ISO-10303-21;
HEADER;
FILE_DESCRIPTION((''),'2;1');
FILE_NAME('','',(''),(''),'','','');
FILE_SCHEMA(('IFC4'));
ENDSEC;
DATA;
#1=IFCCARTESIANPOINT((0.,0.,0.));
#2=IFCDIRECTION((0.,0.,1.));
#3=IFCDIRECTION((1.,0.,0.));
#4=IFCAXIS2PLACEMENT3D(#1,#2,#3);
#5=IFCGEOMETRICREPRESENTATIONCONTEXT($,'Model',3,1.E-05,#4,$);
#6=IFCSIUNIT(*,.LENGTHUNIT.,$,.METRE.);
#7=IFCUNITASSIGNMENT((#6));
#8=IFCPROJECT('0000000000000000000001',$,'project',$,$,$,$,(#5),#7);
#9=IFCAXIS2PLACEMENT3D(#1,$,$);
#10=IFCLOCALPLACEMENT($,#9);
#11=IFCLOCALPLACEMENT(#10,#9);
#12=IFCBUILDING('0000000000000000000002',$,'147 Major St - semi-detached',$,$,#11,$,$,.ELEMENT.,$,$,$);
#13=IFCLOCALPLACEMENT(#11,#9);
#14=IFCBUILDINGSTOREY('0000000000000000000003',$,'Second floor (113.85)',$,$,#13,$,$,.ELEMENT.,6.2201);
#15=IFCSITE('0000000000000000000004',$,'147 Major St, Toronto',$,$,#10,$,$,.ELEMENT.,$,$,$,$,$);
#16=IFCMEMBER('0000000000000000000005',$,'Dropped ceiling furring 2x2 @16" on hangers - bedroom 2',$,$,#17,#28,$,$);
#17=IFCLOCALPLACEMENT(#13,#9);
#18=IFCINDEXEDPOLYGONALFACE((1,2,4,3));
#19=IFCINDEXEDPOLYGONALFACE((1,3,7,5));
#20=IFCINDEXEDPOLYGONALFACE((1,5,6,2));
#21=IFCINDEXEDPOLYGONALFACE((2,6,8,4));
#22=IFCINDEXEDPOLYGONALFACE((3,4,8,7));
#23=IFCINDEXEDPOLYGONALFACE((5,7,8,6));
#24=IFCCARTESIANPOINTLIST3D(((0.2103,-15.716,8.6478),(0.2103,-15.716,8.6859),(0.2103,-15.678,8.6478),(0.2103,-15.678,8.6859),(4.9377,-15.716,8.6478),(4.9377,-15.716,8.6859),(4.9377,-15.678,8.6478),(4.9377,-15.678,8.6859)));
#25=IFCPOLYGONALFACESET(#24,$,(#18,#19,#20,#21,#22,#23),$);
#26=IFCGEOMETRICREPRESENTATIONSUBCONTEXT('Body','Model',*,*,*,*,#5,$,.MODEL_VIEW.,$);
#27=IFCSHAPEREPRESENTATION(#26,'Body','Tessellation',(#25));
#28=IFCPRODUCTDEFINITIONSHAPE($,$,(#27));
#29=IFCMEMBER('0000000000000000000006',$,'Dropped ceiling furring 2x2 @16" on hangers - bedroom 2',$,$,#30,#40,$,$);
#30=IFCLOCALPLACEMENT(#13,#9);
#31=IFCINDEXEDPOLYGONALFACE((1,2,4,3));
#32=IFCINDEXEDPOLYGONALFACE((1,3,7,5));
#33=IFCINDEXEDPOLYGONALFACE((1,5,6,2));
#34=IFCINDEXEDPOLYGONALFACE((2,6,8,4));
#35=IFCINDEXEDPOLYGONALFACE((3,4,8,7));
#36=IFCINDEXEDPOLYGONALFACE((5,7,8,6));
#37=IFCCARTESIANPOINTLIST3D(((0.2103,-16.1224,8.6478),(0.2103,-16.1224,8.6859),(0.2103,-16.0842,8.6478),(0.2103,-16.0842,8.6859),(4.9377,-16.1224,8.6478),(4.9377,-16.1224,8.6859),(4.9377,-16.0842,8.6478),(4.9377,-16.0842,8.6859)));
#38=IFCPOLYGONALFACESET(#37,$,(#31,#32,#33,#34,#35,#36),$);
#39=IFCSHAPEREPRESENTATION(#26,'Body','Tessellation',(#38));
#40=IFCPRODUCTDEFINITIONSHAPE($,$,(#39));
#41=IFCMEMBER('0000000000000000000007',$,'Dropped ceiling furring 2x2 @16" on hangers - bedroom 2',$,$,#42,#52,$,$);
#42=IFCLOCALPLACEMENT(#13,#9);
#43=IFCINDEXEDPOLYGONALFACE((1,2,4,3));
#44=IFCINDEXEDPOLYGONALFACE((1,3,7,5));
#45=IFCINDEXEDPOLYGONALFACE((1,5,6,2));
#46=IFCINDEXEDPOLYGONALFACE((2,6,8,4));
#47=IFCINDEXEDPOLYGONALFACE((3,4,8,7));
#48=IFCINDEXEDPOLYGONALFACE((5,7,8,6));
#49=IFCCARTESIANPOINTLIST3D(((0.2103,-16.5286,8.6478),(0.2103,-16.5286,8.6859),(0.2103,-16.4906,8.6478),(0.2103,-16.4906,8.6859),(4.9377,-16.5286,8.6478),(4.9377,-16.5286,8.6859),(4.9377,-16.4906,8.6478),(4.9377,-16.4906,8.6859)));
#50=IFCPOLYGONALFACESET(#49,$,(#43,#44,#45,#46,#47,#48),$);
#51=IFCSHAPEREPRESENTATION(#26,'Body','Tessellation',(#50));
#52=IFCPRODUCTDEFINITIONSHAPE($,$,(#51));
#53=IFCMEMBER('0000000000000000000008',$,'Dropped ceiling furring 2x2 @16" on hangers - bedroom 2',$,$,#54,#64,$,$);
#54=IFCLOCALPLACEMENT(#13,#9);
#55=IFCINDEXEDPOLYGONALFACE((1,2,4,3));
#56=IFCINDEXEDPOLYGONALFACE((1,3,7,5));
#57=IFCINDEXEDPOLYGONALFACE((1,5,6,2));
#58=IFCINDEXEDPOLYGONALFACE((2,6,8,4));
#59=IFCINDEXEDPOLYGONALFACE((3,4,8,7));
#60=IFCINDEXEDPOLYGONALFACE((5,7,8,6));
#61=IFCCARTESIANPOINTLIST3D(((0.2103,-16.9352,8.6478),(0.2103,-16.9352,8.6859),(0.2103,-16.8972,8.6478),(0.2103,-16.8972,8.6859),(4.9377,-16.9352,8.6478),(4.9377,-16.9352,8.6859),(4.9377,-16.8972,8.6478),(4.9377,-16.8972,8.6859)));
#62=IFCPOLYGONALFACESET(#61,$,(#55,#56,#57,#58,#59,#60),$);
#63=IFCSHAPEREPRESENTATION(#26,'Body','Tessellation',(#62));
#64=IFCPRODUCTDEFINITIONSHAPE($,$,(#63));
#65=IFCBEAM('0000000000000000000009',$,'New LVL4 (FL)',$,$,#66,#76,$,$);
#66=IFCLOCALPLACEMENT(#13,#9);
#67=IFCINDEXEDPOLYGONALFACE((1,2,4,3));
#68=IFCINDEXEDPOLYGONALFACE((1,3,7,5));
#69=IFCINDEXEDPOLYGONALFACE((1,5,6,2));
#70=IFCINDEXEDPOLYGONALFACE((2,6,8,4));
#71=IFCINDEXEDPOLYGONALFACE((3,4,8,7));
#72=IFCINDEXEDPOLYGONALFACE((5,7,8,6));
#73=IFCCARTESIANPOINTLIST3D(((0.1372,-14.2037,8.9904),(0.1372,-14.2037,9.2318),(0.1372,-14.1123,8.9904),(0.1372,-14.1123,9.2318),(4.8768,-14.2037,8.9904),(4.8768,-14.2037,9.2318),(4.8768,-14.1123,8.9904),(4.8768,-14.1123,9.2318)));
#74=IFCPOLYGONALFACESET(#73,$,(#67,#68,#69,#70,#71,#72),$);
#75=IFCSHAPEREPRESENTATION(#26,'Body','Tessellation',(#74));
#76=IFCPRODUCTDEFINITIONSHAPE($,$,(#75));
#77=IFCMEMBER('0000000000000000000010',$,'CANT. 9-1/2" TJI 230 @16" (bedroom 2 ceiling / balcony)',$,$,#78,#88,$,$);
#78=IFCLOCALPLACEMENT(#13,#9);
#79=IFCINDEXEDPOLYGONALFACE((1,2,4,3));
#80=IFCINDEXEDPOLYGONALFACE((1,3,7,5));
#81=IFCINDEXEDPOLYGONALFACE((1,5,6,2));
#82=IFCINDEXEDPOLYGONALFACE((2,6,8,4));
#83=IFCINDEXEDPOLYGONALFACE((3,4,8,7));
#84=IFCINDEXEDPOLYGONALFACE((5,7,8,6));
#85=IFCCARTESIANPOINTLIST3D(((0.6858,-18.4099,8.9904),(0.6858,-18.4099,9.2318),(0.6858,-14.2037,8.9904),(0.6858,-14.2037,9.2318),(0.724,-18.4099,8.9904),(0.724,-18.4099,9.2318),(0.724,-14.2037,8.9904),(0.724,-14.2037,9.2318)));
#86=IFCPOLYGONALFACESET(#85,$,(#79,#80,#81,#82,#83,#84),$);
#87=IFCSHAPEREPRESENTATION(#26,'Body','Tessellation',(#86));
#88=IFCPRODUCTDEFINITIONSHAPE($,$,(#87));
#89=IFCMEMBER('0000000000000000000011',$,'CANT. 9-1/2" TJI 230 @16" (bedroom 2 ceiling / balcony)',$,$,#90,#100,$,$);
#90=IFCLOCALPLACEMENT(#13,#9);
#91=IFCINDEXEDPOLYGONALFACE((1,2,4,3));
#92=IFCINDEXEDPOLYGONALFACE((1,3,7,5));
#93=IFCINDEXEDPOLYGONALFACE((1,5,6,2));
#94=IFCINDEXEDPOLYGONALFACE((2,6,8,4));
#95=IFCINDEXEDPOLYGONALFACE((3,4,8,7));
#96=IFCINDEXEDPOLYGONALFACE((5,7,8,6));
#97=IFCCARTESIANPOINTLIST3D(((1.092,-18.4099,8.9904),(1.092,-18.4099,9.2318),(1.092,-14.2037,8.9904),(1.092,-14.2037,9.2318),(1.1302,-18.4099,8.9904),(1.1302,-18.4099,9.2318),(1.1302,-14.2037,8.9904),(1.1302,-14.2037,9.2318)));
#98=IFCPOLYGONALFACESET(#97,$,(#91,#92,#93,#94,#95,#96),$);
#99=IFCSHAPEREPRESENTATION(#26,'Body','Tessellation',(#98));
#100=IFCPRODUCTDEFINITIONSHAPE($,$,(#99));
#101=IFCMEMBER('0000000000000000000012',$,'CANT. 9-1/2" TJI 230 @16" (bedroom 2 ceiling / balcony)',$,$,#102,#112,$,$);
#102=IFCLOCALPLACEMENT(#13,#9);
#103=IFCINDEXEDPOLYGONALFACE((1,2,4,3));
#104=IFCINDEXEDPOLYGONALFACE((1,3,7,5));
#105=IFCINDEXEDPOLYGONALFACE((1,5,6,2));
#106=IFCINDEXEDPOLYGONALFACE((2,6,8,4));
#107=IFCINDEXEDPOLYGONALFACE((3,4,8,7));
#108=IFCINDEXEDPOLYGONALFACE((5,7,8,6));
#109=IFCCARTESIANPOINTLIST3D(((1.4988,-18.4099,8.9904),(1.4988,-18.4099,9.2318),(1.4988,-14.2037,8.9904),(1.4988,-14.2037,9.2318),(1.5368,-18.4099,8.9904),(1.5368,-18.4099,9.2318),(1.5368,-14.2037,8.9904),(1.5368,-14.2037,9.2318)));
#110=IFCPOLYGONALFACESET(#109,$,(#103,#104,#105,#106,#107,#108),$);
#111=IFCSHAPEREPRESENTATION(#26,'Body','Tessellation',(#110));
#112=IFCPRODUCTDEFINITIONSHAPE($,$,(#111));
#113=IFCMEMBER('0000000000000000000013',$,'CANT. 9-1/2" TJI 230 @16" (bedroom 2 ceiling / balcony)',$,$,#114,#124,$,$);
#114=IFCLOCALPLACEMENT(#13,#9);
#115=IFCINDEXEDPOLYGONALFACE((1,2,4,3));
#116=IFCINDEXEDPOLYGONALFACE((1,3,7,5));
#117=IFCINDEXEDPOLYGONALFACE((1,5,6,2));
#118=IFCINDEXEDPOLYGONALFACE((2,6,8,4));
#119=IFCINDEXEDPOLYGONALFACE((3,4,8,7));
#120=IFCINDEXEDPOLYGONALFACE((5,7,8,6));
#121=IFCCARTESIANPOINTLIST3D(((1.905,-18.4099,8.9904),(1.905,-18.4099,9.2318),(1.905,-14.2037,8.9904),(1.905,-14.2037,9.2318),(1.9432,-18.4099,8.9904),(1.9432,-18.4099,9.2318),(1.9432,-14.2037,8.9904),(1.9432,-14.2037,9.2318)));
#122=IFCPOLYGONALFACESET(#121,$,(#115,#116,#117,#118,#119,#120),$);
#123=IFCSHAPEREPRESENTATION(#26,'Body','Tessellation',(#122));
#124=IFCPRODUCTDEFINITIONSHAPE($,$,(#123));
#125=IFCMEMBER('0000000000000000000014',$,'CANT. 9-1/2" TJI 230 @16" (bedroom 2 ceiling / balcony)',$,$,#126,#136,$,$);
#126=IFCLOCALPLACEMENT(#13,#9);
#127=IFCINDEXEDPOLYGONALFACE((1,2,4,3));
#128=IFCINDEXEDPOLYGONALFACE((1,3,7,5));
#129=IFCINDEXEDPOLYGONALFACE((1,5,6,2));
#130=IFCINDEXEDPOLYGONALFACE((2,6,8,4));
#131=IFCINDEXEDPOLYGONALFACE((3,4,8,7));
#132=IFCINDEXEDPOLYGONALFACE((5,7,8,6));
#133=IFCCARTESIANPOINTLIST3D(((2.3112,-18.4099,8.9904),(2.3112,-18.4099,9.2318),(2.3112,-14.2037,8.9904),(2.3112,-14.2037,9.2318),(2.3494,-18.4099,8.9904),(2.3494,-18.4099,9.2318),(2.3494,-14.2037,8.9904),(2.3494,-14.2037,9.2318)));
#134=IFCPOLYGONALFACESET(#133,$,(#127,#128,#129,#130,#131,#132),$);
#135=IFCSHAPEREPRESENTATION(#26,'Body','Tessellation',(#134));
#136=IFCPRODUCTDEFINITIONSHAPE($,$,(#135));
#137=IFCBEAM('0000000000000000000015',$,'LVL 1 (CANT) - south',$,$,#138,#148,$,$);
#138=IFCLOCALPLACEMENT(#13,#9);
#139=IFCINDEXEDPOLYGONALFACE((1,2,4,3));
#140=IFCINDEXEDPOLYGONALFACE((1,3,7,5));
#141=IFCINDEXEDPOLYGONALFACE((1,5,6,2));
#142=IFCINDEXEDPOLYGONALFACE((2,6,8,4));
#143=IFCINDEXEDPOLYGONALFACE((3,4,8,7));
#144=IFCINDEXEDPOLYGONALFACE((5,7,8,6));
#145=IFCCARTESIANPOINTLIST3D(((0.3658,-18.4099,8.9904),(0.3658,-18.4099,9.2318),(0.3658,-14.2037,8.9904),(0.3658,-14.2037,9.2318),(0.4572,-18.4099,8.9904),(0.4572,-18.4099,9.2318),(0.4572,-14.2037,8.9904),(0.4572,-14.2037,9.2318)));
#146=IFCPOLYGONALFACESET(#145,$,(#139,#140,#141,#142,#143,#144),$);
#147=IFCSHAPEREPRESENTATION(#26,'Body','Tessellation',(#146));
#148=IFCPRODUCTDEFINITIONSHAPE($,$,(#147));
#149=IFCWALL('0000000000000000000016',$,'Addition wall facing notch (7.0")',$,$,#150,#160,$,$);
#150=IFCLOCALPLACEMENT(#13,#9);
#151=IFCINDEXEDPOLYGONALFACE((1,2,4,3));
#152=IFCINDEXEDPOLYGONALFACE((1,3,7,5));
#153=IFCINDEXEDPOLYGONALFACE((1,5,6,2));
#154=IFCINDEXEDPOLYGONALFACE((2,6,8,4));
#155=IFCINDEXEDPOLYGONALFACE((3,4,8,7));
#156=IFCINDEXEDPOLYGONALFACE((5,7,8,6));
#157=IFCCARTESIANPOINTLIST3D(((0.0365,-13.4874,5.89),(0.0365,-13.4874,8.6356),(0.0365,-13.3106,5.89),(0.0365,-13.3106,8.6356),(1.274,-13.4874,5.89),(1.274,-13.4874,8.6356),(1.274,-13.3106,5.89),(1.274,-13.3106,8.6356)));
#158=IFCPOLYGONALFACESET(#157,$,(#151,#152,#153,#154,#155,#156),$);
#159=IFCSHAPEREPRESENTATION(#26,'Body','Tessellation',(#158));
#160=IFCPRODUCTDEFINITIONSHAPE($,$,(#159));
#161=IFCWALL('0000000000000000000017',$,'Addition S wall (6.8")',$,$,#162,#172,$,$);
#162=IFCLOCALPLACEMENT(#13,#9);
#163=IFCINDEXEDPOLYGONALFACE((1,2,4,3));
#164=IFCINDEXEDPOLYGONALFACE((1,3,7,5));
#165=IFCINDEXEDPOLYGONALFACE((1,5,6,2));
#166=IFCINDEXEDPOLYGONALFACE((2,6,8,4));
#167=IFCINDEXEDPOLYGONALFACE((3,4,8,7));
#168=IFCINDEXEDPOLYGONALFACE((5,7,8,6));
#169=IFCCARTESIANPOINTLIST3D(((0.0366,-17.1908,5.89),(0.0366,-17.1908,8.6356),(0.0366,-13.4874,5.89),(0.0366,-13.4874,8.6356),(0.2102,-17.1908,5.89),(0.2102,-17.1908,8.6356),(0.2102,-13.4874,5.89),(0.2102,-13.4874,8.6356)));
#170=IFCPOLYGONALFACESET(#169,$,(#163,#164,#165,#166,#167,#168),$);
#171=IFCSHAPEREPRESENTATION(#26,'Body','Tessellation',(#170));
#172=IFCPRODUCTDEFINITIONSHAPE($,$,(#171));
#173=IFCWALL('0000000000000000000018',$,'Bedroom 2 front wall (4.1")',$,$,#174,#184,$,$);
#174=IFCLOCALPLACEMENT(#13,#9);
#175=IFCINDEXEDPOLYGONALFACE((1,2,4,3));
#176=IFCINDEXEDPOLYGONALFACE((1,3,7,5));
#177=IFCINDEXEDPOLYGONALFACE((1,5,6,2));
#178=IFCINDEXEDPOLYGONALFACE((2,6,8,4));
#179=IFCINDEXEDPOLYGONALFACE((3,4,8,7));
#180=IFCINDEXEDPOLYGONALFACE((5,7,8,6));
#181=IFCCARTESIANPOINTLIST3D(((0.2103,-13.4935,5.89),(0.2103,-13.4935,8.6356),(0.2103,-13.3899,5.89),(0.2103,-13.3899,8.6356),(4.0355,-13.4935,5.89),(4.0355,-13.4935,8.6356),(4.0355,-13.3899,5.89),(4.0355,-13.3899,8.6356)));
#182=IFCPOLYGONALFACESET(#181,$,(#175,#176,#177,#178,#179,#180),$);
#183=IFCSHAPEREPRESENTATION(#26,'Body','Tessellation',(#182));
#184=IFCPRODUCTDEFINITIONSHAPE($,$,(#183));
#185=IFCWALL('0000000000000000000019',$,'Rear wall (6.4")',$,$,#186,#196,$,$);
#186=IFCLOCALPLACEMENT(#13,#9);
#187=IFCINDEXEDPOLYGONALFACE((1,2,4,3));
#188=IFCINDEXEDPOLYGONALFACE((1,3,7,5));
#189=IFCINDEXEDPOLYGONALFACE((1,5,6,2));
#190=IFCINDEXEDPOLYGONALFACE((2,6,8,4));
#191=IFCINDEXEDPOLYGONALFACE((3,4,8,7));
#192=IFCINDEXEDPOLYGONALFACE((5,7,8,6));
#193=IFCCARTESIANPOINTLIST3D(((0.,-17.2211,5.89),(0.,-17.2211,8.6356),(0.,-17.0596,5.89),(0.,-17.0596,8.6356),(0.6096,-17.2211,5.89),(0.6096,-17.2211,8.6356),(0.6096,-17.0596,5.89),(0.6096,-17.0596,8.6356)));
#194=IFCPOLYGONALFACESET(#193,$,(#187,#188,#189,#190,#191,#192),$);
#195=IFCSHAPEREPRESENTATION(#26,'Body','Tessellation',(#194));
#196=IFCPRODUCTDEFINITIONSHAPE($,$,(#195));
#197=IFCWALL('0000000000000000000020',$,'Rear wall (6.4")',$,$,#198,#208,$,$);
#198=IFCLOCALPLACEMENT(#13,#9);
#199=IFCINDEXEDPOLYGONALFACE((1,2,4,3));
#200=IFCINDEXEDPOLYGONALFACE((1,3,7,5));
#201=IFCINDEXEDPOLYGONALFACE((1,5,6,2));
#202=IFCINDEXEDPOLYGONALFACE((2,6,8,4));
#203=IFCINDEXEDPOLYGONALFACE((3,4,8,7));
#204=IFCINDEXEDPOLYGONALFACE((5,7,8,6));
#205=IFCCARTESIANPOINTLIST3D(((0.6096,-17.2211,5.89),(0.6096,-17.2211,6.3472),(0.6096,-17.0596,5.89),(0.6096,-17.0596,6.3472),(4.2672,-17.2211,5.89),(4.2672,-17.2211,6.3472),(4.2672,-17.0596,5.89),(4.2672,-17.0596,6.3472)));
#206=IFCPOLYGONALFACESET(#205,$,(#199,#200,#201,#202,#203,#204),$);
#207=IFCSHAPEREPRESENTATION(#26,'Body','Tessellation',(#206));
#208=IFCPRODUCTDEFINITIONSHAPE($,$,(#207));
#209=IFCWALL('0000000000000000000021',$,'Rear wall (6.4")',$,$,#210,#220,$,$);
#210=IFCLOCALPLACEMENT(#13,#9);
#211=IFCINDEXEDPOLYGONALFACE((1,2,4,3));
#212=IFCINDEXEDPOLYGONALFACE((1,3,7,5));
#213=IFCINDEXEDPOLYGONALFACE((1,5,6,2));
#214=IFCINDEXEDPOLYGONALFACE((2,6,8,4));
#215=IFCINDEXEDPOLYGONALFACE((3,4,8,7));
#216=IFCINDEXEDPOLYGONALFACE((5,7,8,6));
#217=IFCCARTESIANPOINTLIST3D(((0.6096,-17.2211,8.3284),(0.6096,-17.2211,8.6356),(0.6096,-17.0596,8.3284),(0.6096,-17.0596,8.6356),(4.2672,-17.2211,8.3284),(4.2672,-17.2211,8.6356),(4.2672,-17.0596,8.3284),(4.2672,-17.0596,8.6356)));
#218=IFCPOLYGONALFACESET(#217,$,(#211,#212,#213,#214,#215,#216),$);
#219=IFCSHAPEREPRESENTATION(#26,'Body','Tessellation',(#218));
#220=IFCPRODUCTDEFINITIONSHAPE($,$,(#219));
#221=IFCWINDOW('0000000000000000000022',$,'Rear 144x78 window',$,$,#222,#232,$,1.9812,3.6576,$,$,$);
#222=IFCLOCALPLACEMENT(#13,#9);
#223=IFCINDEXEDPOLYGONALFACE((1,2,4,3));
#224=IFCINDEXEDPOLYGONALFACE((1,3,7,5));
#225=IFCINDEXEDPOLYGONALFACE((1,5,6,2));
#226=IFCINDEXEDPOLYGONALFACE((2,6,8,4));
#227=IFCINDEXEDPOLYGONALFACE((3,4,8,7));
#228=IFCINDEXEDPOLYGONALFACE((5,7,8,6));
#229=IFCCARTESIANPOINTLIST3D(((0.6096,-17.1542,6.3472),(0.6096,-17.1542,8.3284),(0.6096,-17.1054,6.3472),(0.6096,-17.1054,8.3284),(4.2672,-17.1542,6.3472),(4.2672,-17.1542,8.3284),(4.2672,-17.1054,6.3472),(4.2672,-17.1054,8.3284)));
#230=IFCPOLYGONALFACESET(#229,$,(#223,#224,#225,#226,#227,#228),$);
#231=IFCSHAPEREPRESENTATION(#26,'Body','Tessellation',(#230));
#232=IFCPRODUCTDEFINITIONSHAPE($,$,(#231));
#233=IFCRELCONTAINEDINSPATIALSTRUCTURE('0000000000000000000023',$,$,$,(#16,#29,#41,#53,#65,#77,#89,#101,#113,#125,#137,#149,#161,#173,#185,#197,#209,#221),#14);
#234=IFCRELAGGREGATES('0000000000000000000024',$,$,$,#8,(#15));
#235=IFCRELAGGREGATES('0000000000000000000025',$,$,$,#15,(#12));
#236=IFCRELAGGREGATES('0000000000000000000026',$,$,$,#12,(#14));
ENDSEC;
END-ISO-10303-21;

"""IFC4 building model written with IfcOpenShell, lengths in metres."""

from ifc_helpers import new_model, si_unit, frame, origin, origin_with_axes, place, context, subcontext, project, spatial, rectangle, extrude, element, save


model = new_model("IFC4")

# Units and contexts
model_context = context("Model", 3, precision=1e-05, world=origin_with_axes())
body_context = subcontext(model_context, "Body", "Model", "MODEL_VIEW")
ifc_project = project(units=[si_unit("LENGTHUNIT", "METRE")], contexts=[model_context])

# Site, building, storey
site_placement = place(None, origin())
site = spatial("IfcSite", under=ifc_project, at=site_placement, Name="147 Major St, Toronto", CompositionType="ELEMENT")
building_placement = place(site_placement, origin())
building = spatial("IfcBuilding", under=site, at=building_placement, Name="147 Major St - semi-detached", CompositionType="ELEMENT")
storey_placement = place(building_placement, origin())
storey = spatial("IfcBuildingStorey", under=building, at=storey_placement, Name="Second floor (113.85)", CompositionType="ELEMENT", Elevation=6.2201)

# Members
for number, where, name in (
    (1, (2.574, -15.697, 8.6478), "Dropped ceiling furring 2x2 @16\" on hangers - bedroom 2"),
    (2, (2.574, -16.1033, 8.6478), "Dropped ceiling furring 2x2 @16\" on hangers - bedroom 2"),
    (3, (2.574, -16.5096, 8.6478), "Dropped ceiling furring 2x2 @16\" on hangers - bedroom 2"),
    (4, (2.574, -16.9162, 8.6478), "Dropped ceiling furring 2x2 @16\" on hangers - bedroom 2"),
):
    element("IfcMember", number, at=place(storey_placement, frame(where)), inside=storey, Name=name, context=body_context, shape_type="SweptSolid", body=[
        extrude(rectangle(XDim=4.7274, YDim=0.0381), origin_with_axes(), (0.0, 0.0, 1.0), 0.0381),
    ])

# Beam
beam_1_placement = place(storey_placement, frame((2.507, -14.158, 8.9904)))
element("IfcBeam", 5, at=beam_1_placement, inside=storey, Name="New LVL4 (FL)", context=body_context, shape_type="SweptSolid", body=[
    extrude(rectangle(XDim=4.7396, YDim=0.0914), origin_with_axes(), (0.0, 0.0, 1.0), 0.2414),
])

# Members
for number, where, name in (
    (6, (0.7049, -16.3068, 8.9904), "CANT. 9-1/2\" TJI 230 @16\" (bedroom 2 ceiling / balcony)"),
    (7, (1.1111, -16.3068, 8.9904), "CANT. 9-1/2\" TJI 230 @16\" (bedroom 2 ceiling / balcony)"),
    (8, (1.5178, -16.3068, 8.9904), "CANT. 9-1/2\" TJI 230 @16\" (bedroom 2 ceiling / balcony)"),
    (9, (1.9241, -16.3068, 8.9904), "CANT. 9-1/2\" TJI 230 @16\" (bedroom 2 ceiling / balcony)"),
    (10, (2.3303, -16.3068, 8.9904), "CANT. 9-1/2\" TJI 230 @16\" (bedroom 2 ceiling / balcony)"),
):
    element("IfcMember", number, at=place(storey_placement, frame(where)), inside=storey, Name=name, context=body_context, shape_type="SweptSolid", body=[
        extrude(rectangle(XDim=0.0381, YDim=4.2062), origin_with_axes(), (0.0, 0.0, 1.0), 0.2414),
    ])

# Beam
beam_2_placement = place(storey_placement, frame((0.4115, -16.3068, 8.9904)))
element("IfcBeam", 11, at=beam_2_placement, inside=storey, Name="LVL 1 (CANT) - south", context=body_context, shape_type="SweptSolid", body=[
    extrude(rectangle(XDim=0.0914, YDim=4.2062), origin_with_axes(), (0.0, 0.0, 1.0), 0.2414),
])

# Walls
wall_1_placement = place(storey_placement, frame((0.6553, -13.399, 5.89)))
element("IfcWall", 12, at=wall_1_placement, inside=storey, Name="Addition wall facing notch (7.0\")", context=body_context, shape_type="SweptSolid", body=[
    extrude(rectangle(XDim=1.2375, YDim=0.1768), origin_with_axes(), (0.0, 0.0, 1.0), 2.7456),
])
wall_2_placement = place(storey_placement, frame((0.1234, -15.3391, 5.89)))
element("IfcWall", 13, at=wall_2_placement, inside=storey, Name="Addition S wall (6.8\")", context=body_context, shape_type="SweptSolid", body=[
    extrude(rectangle(XDim=0.1737, YDim=3.7033), origin_with_axes(), (0.0, 0.0, 1.0), 2.7456),
])
wall_3_placement = place(storey_placement, frame((2.1229, -13.4417, 5.89)))
element("IfcWall", 14, at=wall_3_placement, inside=storey, Name="Bedroom 2 front wall (4.1\")", context=body_context, shape_type="SweptSolid", body=[
    extrude(rectangle(XDim=3.8252, YDim=0.1036), origin_with_axes(), (0.0, 0.0, 1.0), 2.7456),
])
wall_4_placement = place(storey_placement, frame((0.3048, -17.1404, 5.89)))
element("IfcWall", 15, at=wall_4_placement, inside=storey, Name="Rear wall (6.4\")", context=body_context, shape_type="SweptSolid", body=[
    extrude(rectangle(XDim=0.6096, YDim=0.1615), origin_with_axes(), (0.0, 0.0, 1.0), 2.7456),
])
wall_5_placement = place(storey_placement, frame((2.4384, -17.1404, 5.89)))
element("IfcWall", 16, at=wall_5_placement, inside=storey, Name="Rear wall (6.4\")", context=body_context, shape_type="SweptSolid", body=[
    extrude(rectangle(XDim=3.6576, YDim=0.1615), origin_with_axes(), (0.0, 0.0, 1.0), 0.4572),
])
wall_6_placement = place(storey_placement, frame((2.4384, -17.1404, 8.3284)))
element("IfcWall", 17, at=wall_6_placement, inside=storey, Name="Rear wall (6.4\")", context=body_context, shape_type="SweptSolid", body=[
    extrude(rectangle(XDim=3.6576, YDim=0.1615), origin_with_axes(), (0.0, 0.0, 1.0), 0.3072),
])

# Window
window_placement = place(storey_placement, frame((2.4384, -17.1298, 6.3472)))
element("IfcWindow", 18, at=window_placement, inside=storey, Name="Rear 144x78 window", OverallHeight=1.9812, OverallWidth=3.6576, context=body_context, shape_type="SweptSolid", body=[
    extrude(rectangle(XDim=3.6576, YDim=0.0488), origin_with_axes(), (0.0, 0.0, 1.0), 1.9812),
])

save(model, "model.ifc")
